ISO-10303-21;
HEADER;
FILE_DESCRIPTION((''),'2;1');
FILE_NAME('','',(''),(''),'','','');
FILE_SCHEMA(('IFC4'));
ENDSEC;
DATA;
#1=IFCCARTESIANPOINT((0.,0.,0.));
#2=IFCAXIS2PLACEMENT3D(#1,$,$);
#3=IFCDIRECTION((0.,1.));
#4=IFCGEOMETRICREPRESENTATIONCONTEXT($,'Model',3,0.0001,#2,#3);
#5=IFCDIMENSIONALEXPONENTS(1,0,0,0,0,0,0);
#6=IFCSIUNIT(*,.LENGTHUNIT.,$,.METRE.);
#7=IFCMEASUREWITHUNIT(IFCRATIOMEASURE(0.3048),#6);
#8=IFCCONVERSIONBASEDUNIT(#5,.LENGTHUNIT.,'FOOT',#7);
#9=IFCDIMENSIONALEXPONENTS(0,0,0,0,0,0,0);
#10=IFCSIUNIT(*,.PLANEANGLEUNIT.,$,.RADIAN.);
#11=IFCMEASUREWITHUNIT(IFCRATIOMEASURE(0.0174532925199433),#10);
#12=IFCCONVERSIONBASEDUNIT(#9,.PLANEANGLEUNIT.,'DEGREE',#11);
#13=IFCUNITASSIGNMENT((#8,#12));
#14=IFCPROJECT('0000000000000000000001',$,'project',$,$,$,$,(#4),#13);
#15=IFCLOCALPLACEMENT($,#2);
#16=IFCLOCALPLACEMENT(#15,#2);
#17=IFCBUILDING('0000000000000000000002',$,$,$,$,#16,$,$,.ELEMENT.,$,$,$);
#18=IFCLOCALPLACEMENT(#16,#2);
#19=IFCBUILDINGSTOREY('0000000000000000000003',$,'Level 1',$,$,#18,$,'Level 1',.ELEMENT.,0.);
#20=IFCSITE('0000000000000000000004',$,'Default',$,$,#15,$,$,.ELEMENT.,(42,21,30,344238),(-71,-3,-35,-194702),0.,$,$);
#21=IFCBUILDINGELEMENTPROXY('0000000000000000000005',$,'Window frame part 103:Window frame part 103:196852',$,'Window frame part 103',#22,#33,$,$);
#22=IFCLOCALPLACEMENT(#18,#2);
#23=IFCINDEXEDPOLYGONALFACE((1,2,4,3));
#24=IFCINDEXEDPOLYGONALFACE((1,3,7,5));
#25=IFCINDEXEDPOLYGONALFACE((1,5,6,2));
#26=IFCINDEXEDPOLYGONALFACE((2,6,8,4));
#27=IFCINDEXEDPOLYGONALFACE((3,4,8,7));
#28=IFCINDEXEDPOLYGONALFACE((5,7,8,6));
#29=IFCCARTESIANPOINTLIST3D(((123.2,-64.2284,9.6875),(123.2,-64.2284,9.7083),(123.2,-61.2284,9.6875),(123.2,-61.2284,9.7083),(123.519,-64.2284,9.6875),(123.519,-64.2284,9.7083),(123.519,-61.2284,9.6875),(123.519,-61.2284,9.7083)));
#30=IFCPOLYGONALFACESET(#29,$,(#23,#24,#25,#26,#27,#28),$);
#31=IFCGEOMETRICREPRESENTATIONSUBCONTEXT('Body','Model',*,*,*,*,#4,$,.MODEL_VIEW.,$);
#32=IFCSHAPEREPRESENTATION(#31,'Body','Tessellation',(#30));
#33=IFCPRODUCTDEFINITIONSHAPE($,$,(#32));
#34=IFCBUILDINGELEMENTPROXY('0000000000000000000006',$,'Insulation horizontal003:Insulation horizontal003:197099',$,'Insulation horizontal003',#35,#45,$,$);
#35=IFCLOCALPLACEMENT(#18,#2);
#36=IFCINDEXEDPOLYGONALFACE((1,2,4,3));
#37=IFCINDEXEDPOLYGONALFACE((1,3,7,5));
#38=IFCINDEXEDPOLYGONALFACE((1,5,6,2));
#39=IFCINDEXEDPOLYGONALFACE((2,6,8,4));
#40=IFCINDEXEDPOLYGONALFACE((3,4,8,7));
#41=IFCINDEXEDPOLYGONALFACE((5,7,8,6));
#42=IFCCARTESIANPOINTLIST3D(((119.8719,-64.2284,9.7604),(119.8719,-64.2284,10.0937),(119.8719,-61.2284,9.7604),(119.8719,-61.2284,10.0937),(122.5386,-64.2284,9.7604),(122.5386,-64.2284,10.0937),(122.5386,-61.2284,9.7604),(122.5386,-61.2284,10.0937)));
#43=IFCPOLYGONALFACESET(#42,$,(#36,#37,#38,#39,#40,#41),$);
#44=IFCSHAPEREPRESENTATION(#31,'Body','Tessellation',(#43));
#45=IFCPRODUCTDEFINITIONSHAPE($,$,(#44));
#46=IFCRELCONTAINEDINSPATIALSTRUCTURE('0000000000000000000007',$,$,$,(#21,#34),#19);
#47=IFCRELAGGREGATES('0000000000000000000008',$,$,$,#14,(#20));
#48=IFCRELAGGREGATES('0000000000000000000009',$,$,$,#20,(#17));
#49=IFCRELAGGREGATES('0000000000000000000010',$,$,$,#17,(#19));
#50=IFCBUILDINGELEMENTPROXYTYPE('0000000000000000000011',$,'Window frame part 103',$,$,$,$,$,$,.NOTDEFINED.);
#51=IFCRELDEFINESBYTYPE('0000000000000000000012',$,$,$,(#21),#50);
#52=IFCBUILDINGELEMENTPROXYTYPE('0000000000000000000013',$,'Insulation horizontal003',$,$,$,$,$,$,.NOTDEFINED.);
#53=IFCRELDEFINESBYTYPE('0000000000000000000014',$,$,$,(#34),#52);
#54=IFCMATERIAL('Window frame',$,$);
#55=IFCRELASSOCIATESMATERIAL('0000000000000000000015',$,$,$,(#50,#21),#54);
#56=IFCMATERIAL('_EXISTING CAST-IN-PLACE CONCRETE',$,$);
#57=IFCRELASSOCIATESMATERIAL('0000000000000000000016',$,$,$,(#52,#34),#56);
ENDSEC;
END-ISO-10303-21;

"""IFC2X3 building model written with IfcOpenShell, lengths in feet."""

from ifc_helpers import new_model, entity, si_unit, converted_unit, direction, frame, frame_2d, origin, origin_2d_with_axis, place, context, subcontext, project, spatial, rectangle, extrude, source, transform, mapped, material, type_object, type_shapes, element, save


model = new_model("IFC2X3")

# Units and contexts
model_context = context("Model", 3, precision=0.0001, world=origin(), true_north=direction((0.0, 1.0)))
body_context = subcontext(model_context, "Body", "Model", "MODEL_VIEW")
ifc_project = project(units=[converted_unit("LENGTHUNIT", "FOOT", entity("IfcRatioMeasure", 0.3048), si_unit("LENGTHUNIT", "METRE"), dimensions=[1, 0, 0, 0, 0, 0, 0]), converted_unit("PLANEANGLEUNIT", "DEGREE", entity("IfcRatioMeasure", 0.0174532925199433), si_unit("PLANEANGLEUNIT", "RADIAN"), dimensions=[0, 0, 0, 0, 0, 0, 0])], contexts=[model_context])

# Site, building, storey
site_placement = place(None, origin())
site = spatial("IfcSite", under=ifc_project, at=site_placement, Name="Default", CompositionType="ELEMENT", RefLatitude=(42, 21, 30, 344238), RefLongitude=(-71, -3, -35, -194702), RefElevation=0.0)
building_placement = place(site_placement, origin())
building = spatial("IfcBuilding", under=site, at=building_placement, CompositionType="ELEMENT")
storey_placement = place(building_placement, origin())
storey = spatial("IfcBuildingStorey", under=building, at=storey_placement, Name="Level 1", LongName="Level 1", CompositionType="ELEMENT", Elevation=0.0)

# Building element proxies
ifc_material_1 = material(Name="_EXISTING CAST-IN-PLACE CONCRETE")
ifc_material_2 = material(Name="Window frame")
building_element_proxy_type_1 = type_object("IfcBuildingElementProxyType", Name="Window frame part 103", PredefinedType="NOTDEFINED", material=ifc_material_2)
shared_shape_1 = source(origin(), body_context, "Body", "SweptSolid", [
    extrude(rectangle(XDim=3.0, YDim=0.319, at=origin_2d_with_axis()), frame((123.3595, -62.7284, 9.6875), z_axis=(0.0, 0.0, 1.0), x_axis=(0.0, 1.0, 0.0)), (0.0, 0.0, 1.0), 0.0208),
])
type_shapes(building_element_proxy_type_1, [shared_shape_1])
proxy_1_placement = place(storey_placement, origin())
element("IfcBuildingElementProxy", 1, at=proxy_1_placement, inside=storey, type_object=building_element_proxy_type_1, material=ifc_material_2, Name="Window frame part 103:Window frame part 103:196852", ObjectType="Window frame part 103", context=body_context, shape_type="MappedRepresentation", body=[
    mapped(shared_shape_1, transform((0.0, 0.0, 0.0), scale=1.0)),
])
building_element_proxy_type_2 = type_object("IfcBuildingElementProxyType", Name="Insulation horizontal003", PredefinedType="NOTDEFINED", material=ifc_material_1)
shared_shape_2 = source(origin(), body_context, "Body", "SweptSolid", [
    extrude(rectangle(XDim=3.0, YDim=2.6667, at=frame_2d((0.0, 0.0), x_axis=(1.0, 0.0))), frame((121.2053, -62.7284, 9.7604), z_axis=(0.0, 0.0, 1.0), x_axis=(0.0, 1.0, 0.0)), (0.0, 0.0, 1.0), 0.3333),
])
type_shapes(building_element_proxy_type_2, [shared_shape_2])
proxy_2_placement = place(storey_placement, origin())
element("IfcBuildingElementProxy", 2, at=proxy_2_placement, inside=storey, type_object=building_element_proxy_type_2, material=ifc_material_1, Name="Insulation horizontal003:Insulation horizontal003:197099", ObjectType="Insulation horizontal003", context=body_context, shape_type="MappedRepresentation", body=[
    mapped(shared_shape_2, transform((0.0, 0.0, 0.0), scale=1.0)),
])

save(model, "model.ifc")
